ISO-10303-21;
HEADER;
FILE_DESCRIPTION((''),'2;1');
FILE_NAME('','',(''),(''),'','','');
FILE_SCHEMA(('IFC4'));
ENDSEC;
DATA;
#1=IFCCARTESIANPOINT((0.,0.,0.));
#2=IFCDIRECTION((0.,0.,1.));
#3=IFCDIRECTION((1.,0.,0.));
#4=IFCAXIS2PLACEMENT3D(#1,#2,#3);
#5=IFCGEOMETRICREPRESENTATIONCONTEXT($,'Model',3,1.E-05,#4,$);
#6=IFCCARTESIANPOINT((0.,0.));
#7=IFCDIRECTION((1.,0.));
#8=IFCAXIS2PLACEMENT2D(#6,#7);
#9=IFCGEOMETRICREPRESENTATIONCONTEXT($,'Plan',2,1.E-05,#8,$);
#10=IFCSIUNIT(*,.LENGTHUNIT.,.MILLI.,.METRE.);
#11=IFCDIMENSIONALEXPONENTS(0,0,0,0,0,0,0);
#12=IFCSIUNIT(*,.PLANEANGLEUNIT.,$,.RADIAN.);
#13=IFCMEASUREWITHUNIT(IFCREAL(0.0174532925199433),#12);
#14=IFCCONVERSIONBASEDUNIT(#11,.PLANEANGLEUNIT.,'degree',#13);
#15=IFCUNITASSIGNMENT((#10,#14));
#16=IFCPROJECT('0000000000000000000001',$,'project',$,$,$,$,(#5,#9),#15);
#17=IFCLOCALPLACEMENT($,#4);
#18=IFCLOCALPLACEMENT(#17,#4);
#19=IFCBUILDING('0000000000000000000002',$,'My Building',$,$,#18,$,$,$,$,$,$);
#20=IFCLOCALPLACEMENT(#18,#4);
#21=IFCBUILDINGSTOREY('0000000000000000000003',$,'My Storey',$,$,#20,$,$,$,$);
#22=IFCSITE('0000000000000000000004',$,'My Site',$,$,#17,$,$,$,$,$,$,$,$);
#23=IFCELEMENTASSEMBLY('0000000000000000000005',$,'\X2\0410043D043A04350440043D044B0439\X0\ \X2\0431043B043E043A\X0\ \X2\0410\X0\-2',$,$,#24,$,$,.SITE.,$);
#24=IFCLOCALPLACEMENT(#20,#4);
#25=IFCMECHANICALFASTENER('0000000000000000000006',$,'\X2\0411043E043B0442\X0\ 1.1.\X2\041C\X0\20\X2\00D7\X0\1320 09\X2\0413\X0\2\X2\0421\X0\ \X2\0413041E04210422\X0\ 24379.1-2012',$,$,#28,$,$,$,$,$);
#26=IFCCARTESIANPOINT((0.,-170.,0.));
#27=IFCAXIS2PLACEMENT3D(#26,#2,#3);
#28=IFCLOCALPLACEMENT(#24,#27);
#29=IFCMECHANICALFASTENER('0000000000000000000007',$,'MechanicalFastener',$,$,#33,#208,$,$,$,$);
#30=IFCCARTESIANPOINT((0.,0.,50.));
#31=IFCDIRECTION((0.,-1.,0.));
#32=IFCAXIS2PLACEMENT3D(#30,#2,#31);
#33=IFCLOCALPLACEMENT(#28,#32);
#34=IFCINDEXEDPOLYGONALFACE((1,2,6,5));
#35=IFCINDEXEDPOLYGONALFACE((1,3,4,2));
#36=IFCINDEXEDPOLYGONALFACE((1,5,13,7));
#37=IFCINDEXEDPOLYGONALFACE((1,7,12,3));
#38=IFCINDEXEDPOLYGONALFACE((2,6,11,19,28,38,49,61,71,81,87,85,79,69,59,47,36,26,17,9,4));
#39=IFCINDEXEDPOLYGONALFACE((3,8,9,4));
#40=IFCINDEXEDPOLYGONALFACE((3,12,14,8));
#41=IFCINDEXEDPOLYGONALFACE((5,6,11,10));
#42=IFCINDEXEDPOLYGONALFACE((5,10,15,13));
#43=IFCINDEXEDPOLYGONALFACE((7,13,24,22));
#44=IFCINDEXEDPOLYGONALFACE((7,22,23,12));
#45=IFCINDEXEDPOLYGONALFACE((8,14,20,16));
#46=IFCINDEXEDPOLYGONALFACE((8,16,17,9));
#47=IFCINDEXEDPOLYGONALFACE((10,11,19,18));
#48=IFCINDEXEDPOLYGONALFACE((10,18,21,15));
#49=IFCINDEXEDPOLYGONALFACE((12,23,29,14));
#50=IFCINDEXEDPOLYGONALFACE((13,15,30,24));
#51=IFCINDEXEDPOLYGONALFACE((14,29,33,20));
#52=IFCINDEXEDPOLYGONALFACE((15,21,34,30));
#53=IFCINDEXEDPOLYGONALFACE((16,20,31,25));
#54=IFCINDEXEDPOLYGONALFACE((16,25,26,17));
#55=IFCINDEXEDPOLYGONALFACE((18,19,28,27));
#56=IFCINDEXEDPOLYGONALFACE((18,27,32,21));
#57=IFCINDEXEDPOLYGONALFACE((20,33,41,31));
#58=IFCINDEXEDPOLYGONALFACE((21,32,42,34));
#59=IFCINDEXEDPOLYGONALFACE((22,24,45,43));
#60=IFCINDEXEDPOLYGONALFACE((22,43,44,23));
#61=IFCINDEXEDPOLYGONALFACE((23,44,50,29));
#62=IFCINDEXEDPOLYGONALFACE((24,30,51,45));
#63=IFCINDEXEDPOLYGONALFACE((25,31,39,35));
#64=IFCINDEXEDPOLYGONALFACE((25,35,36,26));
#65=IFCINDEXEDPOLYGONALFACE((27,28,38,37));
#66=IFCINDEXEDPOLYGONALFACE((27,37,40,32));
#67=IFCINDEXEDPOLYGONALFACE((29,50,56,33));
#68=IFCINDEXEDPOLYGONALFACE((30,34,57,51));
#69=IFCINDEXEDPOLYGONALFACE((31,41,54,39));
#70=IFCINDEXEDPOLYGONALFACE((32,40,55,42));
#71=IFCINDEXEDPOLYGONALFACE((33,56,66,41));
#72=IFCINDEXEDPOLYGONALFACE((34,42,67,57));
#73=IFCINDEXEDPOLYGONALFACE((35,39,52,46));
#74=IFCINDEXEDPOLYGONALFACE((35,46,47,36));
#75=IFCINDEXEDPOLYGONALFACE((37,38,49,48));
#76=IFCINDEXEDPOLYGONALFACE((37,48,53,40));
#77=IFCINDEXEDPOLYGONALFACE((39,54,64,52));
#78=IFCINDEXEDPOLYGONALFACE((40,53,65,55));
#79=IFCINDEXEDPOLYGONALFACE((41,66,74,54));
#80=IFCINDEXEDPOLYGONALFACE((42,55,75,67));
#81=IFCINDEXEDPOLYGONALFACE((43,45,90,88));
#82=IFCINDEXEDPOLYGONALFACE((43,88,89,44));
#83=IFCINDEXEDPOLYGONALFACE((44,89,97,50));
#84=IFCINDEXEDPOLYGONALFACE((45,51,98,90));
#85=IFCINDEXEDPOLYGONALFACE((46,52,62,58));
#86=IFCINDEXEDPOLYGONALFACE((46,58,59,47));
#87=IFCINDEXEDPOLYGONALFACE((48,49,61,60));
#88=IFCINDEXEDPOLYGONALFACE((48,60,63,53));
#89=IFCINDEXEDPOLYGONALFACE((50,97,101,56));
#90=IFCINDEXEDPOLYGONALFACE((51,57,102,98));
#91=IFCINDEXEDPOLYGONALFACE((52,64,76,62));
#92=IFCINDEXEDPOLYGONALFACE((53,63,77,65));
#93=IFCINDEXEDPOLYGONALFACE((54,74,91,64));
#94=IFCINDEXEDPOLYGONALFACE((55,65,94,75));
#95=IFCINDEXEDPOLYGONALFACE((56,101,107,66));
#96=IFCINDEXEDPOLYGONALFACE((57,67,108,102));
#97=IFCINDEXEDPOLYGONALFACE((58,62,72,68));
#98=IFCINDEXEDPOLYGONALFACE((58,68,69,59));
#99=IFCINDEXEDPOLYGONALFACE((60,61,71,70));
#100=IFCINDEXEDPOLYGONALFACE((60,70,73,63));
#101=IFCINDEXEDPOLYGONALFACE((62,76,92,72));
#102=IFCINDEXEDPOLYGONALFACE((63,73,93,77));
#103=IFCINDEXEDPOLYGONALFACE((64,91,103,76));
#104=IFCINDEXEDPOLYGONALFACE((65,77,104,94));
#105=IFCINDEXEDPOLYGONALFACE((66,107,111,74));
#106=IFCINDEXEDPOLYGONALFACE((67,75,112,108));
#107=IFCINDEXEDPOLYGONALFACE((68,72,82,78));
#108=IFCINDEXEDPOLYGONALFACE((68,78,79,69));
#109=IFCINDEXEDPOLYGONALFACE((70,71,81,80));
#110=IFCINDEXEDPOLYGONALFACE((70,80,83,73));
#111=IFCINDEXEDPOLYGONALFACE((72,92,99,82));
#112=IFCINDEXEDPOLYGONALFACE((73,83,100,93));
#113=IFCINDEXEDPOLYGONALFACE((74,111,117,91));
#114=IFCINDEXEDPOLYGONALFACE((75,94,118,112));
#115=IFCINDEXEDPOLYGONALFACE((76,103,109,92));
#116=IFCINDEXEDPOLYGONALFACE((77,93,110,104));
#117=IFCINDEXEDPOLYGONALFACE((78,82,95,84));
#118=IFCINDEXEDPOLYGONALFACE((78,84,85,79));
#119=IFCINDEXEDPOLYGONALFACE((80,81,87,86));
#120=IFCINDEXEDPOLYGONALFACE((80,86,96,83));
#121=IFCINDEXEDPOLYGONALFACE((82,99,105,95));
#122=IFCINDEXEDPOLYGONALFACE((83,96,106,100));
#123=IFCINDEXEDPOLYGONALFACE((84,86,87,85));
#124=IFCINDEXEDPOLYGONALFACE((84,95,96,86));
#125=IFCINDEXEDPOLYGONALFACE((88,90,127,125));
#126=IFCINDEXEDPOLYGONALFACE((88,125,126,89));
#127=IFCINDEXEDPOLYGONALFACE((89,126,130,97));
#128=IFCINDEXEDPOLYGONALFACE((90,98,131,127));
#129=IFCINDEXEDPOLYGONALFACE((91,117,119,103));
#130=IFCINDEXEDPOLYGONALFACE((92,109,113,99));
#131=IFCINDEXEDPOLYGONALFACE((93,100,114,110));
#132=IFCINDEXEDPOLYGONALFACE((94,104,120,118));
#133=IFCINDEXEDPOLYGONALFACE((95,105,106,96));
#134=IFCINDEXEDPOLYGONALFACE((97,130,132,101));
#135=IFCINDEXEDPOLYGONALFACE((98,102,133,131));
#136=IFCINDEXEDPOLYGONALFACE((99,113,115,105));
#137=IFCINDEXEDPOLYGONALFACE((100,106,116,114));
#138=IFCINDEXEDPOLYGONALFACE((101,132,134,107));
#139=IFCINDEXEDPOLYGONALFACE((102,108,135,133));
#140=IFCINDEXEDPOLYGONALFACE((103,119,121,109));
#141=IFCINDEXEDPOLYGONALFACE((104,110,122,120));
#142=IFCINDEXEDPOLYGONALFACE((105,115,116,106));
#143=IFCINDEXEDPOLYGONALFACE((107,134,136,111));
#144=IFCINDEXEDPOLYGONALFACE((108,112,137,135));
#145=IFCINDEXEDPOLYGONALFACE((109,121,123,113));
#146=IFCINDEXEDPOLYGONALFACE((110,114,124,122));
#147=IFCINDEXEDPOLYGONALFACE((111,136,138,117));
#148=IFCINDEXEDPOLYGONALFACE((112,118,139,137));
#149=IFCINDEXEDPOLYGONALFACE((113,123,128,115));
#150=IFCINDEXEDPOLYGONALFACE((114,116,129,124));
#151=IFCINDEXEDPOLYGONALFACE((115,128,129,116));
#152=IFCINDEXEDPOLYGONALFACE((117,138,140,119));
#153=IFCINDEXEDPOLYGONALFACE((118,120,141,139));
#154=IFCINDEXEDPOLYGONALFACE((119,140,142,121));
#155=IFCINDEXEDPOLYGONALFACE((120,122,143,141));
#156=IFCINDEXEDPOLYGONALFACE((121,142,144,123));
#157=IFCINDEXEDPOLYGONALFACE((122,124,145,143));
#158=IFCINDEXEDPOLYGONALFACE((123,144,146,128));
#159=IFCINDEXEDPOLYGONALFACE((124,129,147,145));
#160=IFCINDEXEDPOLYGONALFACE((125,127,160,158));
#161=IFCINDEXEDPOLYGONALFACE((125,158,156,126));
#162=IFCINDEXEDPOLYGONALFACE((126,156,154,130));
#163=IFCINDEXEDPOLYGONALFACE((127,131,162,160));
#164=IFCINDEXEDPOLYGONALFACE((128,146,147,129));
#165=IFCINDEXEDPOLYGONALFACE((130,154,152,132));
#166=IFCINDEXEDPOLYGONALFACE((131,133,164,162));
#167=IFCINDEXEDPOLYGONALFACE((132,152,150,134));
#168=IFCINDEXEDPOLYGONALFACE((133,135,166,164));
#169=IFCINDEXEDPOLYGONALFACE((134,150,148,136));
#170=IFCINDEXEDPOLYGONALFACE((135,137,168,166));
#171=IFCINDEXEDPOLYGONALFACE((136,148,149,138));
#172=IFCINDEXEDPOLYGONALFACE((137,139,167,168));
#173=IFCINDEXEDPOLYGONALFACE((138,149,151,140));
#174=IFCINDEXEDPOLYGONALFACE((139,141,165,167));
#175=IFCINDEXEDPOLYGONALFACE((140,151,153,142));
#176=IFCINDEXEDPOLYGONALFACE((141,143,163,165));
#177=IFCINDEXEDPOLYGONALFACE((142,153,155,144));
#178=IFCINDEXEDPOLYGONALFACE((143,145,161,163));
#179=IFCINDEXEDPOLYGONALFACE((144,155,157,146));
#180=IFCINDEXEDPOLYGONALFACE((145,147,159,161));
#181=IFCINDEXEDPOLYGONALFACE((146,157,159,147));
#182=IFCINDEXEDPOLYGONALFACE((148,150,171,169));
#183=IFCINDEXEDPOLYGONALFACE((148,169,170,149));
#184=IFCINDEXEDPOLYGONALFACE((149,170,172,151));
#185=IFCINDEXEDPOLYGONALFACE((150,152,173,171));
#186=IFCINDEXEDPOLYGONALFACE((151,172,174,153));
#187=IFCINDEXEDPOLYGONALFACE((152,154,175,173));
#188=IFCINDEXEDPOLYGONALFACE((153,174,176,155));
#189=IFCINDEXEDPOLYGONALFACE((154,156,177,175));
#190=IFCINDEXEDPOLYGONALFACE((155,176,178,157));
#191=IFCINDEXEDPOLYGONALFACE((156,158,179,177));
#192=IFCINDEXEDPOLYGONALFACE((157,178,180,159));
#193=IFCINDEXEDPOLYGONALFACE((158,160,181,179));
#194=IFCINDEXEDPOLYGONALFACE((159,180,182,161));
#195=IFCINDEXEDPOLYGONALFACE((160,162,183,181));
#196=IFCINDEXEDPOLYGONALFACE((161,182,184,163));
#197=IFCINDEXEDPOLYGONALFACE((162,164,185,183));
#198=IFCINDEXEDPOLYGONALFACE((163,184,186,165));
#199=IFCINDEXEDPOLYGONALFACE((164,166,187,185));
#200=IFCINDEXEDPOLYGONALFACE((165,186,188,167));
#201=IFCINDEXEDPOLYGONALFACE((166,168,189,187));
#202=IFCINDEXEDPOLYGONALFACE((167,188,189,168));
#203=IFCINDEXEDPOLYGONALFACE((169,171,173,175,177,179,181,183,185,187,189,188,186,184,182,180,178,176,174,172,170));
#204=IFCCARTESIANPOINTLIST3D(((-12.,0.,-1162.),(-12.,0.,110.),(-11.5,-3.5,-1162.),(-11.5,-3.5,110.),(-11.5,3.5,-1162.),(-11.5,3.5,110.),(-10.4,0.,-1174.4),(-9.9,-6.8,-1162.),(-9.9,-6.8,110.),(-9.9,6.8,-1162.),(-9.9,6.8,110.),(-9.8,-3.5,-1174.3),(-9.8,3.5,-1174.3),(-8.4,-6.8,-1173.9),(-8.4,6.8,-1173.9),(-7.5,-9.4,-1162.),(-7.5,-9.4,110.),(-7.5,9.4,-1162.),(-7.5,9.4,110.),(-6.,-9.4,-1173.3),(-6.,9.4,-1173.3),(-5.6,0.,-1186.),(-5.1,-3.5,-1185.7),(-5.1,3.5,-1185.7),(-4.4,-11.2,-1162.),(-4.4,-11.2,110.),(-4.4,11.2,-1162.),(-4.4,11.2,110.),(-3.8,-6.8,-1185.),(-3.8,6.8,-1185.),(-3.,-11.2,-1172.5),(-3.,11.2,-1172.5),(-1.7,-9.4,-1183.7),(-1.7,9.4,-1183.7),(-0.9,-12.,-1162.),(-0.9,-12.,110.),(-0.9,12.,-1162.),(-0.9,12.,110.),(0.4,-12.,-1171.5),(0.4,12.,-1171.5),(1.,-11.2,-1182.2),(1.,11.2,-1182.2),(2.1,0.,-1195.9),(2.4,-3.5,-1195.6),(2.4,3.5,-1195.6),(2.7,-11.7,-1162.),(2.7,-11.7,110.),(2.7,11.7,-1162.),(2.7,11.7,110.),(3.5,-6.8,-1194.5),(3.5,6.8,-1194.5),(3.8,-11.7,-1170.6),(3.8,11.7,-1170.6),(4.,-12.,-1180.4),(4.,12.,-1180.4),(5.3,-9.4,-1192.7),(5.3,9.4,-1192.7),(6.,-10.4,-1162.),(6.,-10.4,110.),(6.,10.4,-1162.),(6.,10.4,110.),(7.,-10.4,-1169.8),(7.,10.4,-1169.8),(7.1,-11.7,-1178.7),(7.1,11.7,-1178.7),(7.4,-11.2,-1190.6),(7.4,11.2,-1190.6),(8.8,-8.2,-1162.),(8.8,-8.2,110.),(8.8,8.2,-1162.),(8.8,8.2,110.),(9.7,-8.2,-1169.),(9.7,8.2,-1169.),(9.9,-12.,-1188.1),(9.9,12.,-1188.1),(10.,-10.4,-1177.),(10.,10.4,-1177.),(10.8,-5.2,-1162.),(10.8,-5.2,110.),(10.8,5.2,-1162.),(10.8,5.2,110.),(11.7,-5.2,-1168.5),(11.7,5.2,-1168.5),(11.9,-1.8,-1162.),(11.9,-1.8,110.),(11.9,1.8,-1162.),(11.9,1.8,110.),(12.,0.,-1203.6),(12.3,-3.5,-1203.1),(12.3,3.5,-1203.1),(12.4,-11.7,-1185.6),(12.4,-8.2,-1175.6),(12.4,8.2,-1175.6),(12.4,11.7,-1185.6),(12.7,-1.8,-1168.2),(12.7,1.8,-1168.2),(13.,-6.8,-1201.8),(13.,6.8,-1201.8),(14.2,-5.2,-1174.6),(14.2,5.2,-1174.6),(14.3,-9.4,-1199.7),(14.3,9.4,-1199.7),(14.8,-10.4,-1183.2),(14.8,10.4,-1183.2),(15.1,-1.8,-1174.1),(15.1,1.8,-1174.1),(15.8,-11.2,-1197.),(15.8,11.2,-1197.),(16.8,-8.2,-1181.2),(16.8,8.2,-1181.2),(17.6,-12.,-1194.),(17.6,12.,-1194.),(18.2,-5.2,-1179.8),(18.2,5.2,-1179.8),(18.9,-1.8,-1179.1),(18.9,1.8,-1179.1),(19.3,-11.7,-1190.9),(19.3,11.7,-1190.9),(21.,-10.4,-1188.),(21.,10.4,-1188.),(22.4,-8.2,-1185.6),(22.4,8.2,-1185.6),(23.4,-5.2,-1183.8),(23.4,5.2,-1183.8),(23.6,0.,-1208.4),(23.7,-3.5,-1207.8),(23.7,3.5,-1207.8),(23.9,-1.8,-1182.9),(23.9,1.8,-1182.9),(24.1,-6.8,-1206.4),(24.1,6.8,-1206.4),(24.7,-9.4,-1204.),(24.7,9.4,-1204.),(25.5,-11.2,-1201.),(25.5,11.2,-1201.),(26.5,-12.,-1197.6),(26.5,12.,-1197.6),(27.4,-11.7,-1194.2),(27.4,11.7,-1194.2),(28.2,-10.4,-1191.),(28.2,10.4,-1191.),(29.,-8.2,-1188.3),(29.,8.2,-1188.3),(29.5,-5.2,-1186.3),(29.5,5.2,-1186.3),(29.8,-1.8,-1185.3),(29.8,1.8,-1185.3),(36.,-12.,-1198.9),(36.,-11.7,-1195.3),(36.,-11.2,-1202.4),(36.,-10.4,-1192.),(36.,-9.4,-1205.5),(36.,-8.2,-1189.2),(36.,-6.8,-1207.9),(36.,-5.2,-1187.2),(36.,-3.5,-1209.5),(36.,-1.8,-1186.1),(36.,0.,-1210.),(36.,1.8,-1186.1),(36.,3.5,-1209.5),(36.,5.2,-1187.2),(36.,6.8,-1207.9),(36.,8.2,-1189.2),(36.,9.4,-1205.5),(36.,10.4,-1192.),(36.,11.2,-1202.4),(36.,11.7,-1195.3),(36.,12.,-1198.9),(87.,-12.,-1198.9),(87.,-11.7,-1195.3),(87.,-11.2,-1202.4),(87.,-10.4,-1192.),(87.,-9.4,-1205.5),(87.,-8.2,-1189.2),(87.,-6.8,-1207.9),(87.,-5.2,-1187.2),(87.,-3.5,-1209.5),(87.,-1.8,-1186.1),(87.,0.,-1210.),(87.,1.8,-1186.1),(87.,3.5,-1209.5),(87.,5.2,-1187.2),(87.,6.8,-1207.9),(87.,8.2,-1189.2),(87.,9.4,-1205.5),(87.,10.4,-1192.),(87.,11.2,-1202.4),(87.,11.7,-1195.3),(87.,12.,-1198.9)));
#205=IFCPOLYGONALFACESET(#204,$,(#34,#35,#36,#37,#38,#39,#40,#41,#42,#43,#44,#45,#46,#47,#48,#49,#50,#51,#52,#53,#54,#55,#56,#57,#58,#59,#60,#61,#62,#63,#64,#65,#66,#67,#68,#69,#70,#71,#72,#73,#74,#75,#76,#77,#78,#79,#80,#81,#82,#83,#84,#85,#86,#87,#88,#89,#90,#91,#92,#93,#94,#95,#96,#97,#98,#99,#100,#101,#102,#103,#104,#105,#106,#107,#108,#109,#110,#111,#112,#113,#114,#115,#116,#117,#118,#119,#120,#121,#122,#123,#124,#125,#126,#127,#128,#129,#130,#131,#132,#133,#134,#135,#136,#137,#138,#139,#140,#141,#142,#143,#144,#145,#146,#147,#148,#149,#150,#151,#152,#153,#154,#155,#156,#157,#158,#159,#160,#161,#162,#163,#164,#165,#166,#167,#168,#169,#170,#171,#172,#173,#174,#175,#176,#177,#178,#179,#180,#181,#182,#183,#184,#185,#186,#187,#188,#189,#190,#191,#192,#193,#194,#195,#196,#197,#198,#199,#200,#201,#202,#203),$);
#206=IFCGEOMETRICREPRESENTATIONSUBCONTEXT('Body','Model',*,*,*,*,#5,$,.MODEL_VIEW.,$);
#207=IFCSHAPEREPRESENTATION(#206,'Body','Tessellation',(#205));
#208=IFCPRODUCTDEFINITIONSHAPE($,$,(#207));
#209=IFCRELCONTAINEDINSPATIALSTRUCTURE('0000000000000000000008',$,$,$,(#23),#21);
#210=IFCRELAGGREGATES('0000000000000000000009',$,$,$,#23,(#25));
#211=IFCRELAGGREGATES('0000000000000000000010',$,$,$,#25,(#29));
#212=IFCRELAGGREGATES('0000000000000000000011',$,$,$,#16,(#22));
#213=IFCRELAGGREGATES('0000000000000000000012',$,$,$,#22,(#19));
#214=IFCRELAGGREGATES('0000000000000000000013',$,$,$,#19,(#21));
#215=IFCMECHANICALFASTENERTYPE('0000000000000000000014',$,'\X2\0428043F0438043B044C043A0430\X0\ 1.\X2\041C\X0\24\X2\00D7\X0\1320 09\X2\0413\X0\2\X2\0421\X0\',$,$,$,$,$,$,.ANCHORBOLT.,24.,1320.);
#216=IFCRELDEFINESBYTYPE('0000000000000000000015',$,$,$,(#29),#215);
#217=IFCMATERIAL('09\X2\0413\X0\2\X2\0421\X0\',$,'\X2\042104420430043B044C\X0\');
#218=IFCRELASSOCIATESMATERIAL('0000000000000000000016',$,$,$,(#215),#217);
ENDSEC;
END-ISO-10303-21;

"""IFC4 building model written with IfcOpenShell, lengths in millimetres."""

from ifc_helpers import new_model, entity, si_unit, converted_unit, frame, origin_with_axes, origin_2d_with_axis, place, context, subcontext, project, spatial, source, transform, mapped, material, type_object, type_shapes, element, aggregate, save


model = new_model("IFC4")

# Units and contexts
model_context = context("Model", 3, precision=1e-05, world=origin_with_axes())
plan_context = context("Plan", 2, precision=1e-05, world=origin_2d_with_axis())
body_context = subcontext(model_context, "Body", "Model", "MODEL_VIEW")
ifc_project = project(units=[si_unit("LENGTHUNIT", "METRE", prefix="MILLI"), converted_unit("PLANEANGLEUNIT", "degree", entity("IfcReal", 0.0174532925199433), si_unit("PLANEANGLEUNIT", "RADIAN"), dimensions=[0, 0, 0, 0, 0, 0, 0])], contexts=[model_context, plan_context])

# Site, building, storey
site_placement = place(None, origin_with_axes())
site = spatial("IfcSite", under=ifc_project, at=site_placement, Name="My Site")
building_placement = place(site_placement, origin_with_axes())
building = spatial("IfcBuilding", under=site, at=building_placement, Name="My Building")
storey_placement = place(building_placement, origin_with_axes())
storey = spatial("IfcBuildingStorey", under=building, at=storey_placement, Name="My Storey")

# Shared definitions
placement = place(storey_placement, origin_with_axes())

# Element assembly, mechanical fasteners
assembly = element("IfcElementAssembly", 1, at=placement, inside=storey, Name="Анкерный блок А-2", AssemblyPlace="SITE")
mechanical_fastener_1_placement = place(placement, frame((0.0, -170.0, 0.0), z_axis=(0.0, 0.0, 1.0), x_axis=(1.0, 0.0, 0.0)))
mechanical_fastener_1 = element("IfcMechanicalFastener", 2, at=mechanical_fastener_1_placement, Name="Болт 1.1.М20×1320 09Г2С ГОСТ 24379.1-2012")
aggregate(assembly, [mechanical_fastener_1])
ifc_material_1 = material(Name="09Г2С", Category="Сталь")
mechanical_fastener_type = type_object("IfcMechanicalFastenerType", Name="Шпилька 1.М24×1320 09Г2С", NominalDiameter=24.0, NominalLength=1320.0, PredefinedType="ANCHORBOLT", material=ifc_material_1)
shared_shape = source(frame((0.0, 0.0, 110.0), z_axis=(0.0, 0.0, 1.0), x_axis=(1.0, 0.0, 0.0)), body_context, "Body", "AdvancedSweptSolid", [
    entity("IfcSweptDiskSolid", entity("IfcIndexedPolyCurve", entity("IfcCartesianPointList3D", [[0.0, 0.0, 0.0], [0.0, 0.0, -1272.0], [10.5, 0.0, -1297.5], [36.0, 0.0, -1308.0], [87.0, 0.0, -1308.0]]), [entity("IfcLineIndex", [1, 2]), entity("IfcArcIndex", [2, 3, 4]), entity("IfcLineIndex", [4, 5])]), 12.0),
])
type_shapes(mechanical_fastener_type, [shared_shape])
mechanical_fastener_2_placement = place(mechanical_fastener_1_placement, frame((0.0, 0.0, 50.0), z_axis=(0.0, 0.0, 1.0), x_axis=(0.0, -1.0, 0.0)))
mechanical_fastener_2 = element("IfcMechanicalFastener", 3, at=mechanical_fastener_2_placement, type_object=mechanical_fastener_type, Name="MechanicalFastener", context=body_context, shape_type="MappedRepresentation", body=[
    mapped(shared_shape, transform((0.0, 0.0, 0.0), x_axis=(1.0, 0.0, 0.0), y_axis=(0.0, 1.0, 0.0), z_axis=(0.0, 0.0, 1.0), scale=1.0)),
])
aggregate(mechanical_fastener_1, [mechanical_fastener_2])

save(model, "model.ifc")
